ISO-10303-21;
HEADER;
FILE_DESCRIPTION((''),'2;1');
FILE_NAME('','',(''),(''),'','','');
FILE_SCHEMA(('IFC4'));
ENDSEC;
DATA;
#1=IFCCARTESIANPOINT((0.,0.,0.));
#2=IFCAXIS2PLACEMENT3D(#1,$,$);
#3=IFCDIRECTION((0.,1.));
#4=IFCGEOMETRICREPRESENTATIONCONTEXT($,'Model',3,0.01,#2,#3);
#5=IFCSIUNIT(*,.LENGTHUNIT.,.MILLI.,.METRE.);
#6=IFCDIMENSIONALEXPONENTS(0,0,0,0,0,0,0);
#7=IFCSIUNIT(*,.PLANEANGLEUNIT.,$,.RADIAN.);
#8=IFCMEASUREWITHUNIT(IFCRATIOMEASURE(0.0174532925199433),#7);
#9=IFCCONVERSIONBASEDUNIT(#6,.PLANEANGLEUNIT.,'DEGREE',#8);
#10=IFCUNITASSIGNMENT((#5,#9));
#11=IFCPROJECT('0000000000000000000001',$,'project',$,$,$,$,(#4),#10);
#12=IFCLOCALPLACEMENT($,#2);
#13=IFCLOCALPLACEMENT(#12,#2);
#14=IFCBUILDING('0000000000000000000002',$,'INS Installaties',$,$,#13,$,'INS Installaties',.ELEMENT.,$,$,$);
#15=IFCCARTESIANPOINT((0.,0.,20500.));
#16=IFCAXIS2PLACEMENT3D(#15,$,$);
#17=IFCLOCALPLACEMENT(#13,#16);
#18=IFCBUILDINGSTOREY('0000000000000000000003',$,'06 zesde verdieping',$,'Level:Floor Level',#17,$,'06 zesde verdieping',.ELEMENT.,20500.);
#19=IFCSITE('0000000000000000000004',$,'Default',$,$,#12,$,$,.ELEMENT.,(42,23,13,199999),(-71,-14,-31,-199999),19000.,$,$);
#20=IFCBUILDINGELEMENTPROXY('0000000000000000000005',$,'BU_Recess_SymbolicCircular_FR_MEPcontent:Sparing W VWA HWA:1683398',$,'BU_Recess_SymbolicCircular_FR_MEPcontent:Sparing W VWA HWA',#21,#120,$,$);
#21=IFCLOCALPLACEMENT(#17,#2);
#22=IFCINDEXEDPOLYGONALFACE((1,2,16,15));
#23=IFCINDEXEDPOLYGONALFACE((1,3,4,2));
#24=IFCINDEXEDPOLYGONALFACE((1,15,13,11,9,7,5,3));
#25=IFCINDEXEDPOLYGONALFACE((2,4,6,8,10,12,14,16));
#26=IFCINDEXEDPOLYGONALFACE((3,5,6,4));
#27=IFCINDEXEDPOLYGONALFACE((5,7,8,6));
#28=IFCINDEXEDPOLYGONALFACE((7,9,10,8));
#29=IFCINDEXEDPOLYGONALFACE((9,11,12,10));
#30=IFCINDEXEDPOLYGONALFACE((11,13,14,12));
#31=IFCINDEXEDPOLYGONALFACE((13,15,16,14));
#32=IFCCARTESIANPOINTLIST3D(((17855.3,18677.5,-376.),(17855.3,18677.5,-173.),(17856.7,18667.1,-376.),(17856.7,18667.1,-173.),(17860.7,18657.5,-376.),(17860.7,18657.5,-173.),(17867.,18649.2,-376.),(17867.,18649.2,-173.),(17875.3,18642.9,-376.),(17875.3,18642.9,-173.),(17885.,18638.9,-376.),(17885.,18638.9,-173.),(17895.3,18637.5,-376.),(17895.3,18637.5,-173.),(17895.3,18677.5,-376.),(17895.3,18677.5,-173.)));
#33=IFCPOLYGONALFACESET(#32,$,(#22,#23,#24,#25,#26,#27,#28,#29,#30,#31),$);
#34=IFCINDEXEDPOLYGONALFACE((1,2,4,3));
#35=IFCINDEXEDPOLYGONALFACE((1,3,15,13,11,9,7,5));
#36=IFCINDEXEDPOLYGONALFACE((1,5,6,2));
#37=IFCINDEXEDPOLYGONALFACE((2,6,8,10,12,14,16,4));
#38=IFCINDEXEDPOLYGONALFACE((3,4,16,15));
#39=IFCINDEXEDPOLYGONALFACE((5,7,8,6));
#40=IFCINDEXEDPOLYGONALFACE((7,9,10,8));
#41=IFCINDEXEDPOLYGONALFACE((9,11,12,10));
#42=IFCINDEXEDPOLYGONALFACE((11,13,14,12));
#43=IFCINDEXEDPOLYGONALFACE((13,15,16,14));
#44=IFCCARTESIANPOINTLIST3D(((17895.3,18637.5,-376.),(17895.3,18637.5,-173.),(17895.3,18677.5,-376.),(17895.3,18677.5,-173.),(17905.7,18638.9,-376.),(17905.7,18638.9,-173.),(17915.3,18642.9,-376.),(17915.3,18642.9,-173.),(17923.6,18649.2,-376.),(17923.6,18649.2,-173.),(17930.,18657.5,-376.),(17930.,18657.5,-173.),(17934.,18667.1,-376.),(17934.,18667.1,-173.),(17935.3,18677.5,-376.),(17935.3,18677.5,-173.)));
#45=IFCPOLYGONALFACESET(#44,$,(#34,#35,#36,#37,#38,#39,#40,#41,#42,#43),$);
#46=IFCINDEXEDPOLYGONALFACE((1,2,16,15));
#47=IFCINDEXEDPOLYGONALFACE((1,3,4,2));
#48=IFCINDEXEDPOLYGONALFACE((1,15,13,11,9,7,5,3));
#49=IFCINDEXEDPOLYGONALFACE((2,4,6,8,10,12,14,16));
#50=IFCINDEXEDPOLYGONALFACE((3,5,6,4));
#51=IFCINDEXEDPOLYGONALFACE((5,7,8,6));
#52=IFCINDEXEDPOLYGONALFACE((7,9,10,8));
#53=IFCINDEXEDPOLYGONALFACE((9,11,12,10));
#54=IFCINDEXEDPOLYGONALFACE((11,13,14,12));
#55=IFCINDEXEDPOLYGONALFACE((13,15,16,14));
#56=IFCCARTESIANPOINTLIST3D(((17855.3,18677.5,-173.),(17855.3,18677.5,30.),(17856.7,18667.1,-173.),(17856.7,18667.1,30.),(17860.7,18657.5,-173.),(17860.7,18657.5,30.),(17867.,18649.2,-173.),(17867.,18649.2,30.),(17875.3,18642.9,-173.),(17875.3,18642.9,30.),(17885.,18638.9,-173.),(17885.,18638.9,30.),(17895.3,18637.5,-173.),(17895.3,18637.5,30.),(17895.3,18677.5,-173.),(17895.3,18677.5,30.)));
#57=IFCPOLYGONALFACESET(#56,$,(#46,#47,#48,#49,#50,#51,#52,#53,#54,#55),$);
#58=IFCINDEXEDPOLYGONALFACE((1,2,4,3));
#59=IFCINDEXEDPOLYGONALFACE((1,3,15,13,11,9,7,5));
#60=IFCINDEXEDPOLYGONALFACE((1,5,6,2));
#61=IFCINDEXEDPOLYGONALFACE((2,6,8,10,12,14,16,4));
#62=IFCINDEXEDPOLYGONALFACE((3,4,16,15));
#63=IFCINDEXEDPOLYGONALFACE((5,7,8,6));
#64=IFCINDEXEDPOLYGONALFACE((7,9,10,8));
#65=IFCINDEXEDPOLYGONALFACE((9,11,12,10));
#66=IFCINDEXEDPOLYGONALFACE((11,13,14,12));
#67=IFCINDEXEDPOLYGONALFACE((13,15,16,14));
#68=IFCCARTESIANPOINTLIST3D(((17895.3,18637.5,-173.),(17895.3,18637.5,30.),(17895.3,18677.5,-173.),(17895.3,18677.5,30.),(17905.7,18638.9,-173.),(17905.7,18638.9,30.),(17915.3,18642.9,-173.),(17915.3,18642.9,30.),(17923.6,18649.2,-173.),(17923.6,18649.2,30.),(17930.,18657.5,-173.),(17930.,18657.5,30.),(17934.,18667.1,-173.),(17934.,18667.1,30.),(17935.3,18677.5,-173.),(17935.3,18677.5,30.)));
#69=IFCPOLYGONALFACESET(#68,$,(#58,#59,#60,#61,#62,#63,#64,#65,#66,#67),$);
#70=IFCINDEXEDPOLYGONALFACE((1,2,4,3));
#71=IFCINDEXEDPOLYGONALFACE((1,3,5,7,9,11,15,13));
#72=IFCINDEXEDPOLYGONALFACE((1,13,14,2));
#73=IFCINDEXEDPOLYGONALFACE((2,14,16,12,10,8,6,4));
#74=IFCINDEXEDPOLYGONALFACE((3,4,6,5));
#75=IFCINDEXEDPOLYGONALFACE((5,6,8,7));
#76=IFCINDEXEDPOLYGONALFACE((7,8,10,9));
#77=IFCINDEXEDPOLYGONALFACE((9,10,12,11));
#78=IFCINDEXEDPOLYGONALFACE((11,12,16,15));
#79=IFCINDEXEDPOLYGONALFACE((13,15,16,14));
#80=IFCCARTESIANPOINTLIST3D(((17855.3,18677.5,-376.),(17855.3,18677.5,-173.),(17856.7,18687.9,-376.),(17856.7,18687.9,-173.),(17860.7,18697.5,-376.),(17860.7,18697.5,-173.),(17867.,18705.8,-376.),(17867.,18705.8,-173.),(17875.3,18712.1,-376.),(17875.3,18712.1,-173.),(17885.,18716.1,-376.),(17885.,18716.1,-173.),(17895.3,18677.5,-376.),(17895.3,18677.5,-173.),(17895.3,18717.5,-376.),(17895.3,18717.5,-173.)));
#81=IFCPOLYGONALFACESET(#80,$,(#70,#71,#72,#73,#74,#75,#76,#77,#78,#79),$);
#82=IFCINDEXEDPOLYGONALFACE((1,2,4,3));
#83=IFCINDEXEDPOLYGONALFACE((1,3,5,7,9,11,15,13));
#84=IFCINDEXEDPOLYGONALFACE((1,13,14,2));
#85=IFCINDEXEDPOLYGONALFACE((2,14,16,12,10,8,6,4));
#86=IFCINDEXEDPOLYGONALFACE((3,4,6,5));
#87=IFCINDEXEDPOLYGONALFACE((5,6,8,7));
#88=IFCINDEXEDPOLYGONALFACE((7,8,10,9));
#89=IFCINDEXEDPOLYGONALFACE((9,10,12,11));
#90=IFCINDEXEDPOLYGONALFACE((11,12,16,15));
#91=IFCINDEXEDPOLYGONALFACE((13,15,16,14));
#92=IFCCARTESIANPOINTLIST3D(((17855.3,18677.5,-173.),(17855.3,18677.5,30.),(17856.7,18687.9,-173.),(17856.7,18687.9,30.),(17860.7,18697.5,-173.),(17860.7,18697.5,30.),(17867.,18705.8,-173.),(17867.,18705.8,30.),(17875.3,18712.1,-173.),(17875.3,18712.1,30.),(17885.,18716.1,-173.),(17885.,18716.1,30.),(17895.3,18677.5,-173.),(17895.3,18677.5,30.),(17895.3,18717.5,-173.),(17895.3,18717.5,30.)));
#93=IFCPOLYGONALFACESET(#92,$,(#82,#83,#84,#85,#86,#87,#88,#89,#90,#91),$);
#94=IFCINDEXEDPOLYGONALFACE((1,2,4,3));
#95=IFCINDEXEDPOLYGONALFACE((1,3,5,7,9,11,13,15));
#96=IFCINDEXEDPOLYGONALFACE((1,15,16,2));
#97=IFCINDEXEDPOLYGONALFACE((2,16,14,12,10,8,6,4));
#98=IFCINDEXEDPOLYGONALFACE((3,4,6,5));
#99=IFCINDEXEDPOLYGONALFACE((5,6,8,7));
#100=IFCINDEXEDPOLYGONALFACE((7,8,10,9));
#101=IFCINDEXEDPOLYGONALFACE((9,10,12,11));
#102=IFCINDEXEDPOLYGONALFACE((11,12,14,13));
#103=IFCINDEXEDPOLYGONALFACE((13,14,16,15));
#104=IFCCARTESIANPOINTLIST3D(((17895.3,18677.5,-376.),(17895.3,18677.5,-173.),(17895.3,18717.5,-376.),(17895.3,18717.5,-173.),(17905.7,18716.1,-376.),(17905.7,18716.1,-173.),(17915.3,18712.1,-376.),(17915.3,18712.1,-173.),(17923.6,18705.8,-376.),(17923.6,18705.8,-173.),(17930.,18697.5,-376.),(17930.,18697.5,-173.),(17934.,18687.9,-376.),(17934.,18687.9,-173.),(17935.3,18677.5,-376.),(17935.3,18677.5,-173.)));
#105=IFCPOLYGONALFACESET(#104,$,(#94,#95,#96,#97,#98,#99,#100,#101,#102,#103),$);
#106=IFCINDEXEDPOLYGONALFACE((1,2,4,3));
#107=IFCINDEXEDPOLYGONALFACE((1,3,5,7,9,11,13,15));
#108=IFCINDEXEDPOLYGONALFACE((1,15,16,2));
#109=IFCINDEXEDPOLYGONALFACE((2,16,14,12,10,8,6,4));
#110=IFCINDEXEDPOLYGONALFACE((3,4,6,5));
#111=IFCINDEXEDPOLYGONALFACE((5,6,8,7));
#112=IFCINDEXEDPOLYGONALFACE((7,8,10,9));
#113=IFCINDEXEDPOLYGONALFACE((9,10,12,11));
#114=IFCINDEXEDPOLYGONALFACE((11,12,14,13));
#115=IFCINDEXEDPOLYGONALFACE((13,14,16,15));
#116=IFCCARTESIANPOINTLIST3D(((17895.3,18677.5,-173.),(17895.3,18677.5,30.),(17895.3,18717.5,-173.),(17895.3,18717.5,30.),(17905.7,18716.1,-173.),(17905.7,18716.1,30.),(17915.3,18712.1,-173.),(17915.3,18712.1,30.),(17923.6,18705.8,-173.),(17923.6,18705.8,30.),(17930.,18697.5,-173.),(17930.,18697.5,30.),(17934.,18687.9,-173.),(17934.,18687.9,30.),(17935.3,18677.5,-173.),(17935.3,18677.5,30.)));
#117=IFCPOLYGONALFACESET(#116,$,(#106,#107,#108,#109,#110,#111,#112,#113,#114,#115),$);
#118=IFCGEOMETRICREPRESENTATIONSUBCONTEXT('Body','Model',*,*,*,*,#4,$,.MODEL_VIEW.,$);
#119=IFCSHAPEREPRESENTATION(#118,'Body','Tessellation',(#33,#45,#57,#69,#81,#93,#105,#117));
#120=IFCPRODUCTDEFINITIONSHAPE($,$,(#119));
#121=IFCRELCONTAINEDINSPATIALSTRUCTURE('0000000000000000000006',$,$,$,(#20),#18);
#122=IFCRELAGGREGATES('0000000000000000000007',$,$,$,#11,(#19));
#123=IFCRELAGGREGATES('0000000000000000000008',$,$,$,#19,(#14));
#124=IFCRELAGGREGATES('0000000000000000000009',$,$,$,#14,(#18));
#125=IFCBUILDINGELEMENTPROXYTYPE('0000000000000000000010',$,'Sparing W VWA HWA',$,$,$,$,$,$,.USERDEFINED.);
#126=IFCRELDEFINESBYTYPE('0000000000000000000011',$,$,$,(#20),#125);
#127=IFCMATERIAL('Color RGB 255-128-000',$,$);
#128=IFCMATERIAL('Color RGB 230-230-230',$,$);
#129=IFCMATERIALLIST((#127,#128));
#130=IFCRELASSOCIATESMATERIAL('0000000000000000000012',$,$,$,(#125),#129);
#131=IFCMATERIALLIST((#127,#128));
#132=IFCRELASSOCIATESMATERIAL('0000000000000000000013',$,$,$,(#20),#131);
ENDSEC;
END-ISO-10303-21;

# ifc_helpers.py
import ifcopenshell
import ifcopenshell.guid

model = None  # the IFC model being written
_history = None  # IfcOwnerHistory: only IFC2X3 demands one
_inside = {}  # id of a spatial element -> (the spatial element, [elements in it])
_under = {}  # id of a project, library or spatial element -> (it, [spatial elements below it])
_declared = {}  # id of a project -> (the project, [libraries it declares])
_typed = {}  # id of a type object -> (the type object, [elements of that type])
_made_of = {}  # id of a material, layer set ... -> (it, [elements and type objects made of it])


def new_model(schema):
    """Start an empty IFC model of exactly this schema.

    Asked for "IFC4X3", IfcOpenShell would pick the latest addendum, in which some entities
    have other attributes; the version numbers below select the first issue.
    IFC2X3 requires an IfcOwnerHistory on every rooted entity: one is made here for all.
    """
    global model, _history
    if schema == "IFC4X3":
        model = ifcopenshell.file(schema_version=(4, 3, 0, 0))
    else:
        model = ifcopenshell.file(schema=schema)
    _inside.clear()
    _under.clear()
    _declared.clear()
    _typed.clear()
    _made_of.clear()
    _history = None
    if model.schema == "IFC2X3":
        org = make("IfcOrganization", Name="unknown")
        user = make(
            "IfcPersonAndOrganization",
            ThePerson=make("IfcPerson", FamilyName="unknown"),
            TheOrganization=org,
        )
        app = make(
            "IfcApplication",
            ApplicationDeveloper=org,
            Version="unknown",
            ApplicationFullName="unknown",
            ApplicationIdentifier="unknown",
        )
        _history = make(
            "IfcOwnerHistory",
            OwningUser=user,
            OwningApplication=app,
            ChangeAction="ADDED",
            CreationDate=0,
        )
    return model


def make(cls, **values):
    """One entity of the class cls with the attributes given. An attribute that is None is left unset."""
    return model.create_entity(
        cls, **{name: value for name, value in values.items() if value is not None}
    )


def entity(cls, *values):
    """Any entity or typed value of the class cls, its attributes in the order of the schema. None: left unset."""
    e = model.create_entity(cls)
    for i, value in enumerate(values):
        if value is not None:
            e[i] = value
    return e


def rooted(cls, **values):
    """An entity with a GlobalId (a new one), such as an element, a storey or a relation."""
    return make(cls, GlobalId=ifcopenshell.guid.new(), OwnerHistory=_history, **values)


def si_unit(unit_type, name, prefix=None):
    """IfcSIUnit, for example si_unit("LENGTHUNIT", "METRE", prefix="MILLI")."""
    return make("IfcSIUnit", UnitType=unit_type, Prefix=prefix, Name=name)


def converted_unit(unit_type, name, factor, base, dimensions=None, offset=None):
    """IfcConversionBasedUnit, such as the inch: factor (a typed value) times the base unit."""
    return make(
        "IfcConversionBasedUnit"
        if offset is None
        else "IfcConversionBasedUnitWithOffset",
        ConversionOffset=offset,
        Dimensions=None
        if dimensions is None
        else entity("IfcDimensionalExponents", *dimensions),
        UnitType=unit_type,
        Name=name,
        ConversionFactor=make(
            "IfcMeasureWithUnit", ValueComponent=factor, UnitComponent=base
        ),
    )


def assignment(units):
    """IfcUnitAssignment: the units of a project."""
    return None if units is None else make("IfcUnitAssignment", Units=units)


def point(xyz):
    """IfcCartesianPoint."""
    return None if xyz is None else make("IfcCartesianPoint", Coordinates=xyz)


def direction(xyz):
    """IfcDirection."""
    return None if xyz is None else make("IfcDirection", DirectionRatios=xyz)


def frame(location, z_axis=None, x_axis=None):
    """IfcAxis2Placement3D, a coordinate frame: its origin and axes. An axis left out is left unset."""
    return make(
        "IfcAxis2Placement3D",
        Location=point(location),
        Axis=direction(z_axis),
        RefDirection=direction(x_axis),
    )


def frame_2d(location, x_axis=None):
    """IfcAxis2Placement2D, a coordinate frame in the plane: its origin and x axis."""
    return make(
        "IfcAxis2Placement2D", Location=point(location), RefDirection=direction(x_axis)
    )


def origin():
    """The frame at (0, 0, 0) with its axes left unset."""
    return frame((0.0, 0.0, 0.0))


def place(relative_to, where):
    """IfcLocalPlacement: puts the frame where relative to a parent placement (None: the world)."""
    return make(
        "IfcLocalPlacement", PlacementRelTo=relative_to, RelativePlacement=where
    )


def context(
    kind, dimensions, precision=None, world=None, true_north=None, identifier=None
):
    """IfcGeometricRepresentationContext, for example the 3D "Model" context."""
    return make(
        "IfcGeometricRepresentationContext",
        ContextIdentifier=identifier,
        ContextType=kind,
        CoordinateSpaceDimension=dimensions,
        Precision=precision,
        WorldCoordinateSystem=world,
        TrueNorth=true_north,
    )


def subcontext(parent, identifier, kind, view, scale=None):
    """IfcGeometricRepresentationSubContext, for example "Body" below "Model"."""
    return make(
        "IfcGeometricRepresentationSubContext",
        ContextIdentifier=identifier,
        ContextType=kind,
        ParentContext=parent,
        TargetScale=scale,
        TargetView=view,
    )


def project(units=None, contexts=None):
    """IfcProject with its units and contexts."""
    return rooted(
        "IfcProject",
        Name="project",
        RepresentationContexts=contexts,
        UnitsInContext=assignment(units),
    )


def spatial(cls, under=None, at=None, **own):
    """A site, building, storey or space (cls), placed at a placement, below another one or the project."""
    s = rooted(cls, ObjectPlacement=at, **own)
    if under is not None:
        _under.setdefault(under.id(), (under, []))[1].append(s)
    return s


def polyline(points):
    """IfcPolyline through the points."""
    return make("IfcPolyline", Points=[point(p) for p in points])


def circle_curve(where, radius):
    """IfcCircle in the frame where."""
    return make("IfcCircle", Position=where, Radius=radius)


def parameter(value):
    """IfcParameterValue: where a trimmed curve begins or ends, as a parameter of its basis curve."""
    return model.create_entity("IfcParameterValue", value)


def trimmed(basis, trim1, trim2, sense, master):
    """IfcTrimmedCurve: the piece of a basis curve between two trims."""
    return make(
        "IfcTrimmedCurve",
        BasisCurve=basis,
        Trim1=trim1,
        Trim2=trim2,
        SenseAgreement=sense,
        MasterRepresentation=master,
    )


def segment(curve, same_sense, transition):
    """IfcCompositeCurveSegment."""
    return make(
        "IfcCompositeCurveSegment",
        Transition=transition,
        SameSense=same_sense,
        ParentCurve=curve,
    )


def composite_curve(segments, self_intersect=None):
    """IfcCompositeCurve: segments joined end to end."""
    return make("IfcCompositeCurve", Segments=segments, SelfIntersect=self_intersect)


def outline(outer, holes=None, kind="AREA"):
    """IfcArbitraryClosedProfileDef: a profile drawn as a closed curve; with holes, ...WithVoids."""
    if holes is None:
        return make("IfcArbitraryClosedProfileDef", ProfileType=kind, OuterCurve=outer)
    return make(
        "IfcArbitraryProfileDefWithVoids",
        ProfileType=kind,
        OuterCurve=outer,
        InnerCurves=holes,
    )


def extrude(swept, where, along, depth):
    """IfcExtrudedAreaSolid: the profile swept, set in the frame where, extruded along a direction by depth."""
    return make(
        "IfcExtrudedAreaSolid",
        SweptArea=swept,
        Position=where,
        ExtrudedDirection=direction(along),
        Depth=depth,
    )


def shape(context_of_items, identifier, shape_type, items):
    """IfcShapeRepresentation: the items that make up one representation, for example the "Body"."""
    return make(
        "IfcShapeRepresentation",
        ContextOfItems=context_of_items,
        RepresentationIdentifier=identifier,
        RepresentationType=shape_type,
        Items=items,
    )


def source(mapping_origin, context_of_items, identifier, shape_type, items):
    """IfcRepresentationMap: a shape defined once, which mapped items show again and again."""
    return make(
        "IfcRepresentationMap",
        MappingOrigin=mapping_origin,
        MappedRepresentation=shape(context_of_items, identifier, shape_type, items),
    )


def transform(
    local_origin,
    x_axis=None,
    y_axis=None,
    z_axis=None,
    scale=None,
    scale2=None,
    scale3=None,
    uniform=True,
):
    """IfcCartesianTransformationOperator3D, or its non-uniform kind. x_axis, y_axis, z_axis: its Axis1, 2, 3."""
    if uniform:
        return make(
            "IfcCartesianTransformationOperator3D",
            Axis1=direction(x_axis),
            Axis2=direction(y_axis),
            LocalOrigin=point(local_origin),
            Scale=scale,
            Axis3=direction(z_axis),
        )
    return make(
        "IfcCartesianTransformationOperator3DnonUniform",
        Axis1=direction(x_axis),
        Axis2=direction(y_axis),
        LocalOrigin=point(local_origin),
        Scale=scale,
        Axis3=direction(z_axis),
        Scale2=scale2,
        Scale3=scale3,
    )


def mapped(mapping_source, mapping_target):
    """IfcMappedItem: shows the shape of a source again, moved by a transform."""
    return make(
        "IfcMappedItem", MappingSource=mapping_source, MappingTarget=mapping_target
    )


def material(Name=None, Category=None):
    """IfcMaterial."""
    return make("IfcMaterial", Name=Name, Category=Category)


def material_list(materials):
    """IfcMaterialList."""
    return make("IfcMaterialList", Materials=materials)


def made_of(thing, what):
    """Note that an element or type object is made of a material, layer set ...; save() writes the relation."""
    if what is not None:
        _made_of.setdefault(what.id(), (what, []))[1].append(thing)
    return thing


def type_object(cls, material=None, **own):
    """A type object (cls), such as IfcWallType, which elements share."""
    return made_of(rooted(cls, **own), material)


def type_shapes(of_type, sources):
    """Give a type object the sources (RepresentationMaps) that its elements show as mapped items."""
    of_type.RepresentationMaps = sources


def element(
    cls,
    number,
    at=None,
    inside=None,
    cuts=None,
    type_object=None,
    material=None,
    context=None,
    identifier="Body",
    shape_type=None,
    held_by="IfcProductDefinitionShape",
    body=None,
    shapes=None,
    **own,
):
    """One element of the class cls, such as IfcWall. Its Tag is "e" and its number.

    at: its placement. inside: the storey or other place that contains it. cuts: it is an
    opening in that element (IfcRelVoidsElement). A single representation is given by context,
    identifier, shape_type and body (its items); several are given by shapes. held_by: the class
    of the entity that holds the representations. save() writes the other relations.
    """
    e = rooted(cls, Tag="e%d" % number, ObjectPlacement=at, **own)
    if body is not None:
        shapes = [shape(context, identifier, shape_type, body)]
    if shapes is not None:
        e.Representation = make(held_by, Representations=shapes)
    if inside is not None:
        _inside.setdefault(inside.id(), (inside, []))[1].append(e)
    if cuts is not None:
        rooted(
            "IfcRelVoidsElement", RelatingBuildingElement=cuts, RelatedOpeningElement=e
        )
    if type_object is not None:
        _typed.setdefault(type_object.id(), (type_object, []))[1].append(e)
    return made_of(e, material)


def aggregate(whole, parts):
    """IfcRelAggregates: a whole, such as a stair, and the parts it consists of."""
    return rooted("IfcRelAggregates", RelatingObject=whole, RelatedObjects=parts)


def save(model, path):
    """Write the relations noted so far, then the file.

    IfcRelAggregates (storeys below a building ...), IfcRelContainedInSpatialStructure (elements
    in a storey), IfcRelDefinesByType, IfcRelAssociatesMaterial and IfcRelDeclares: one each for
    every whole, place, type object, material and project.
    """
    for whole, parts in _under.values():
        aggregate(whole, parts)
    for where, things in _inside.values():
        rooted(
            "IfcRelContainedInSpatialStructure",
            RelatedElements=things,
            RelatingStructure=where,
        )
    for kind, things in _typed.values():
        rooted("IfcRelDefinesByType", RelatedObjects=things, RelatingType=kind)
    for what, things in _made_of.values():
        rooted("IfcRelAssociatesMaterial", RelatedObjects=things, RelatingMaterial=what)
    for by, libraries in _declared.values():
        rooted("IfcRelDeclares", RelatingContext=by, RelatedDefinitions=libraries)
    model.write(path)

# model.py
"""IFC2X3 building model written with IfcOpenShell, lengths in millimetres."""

from ifc_helpers import new_model, entity, si_unit, converted_unit, direction, frame, frame_2d, origin, place, context, subcontext, project, spatial, polyline, circle_curve, parameter, trimmed, segment, composite_curve, outline, extrude, source, transform, mapped, material, material_list, type_object, type_shapes, element, save


model = new_model("IFC2X3")

# Units and contexts
model_context = context("Model", 3, precision=0.01, world=origin(), true_north=direction((0.0, 1.0)))
body_context = subcontext(model_context, "Body", "Model", "MODEL_VIEW")
ifc_project = project(units=[si_unit("LENGTHUNIT", "METRE", prefix="MILLI"), converted_unit("PLANEANGLEUNIT", "DEGREE", entity("IfcRatioMeasure", 0.0174532925199433), si_unit("PLANEANGLEUNIT", "RADIAN"), dimensions=[0, 0, 0, 0, 0, 0, 0])], contexts=[model_context])

# Site, building, storey
site_placement = place(None, origin())
site = spatial("IfcSite", under=ifc_project, at=site_placement, Name="Default", CompositionType="ELEMENT", RefLatitude=(42, 23, 13, 199999), RefLongitude=(-71, -14, -31, -199999), RefElevation=19000.0)
building_placement = place(site_placement, origin())
building = spatial("IfcBuilding", under=site, at=building_placement, Name="INS Installaties", LongName="INS Installaties", CompositionType="ELEMENT")
storey_placement = place(building_placement, frame((0.0, 0.0, 20500.0)))
storey = spatial("IfcBuildingStorey", under=building, at=storey_placement, Name="06 zesde verdieping", ObjectType="Level:Floor Level", LongName="06 zesde verdieping", CompositionType="ELEMENT", Elevation=20500.0)

# Building element proxy
ifc_material_1 = material(Name="Color RGB 255-128-000")
ifc_material_2 = material(Name="Color RGB 230-230-230")
ifc_material_list_1 = material_list([ifc_material_1, ifc_material_2])
building_element_proxy_type_1 = type_object("IfcBuildingElementProxyType", Name="Sparing W VWA HWA", PredefinedType="USERDEFINED", material=ifc_material_list_1)
shared_shape_1 = source(origin(), body_context, "Body", "SweptSolid", [
    extrude(outline(composite_curve([segment(trimmed(circle_curve(frame_2d((13.3, 13.3), x_axis=(1.0, 0.0)), 40.0), [parameter(180.0)], [parameter(270.0)], True, "PARAMETER"), True, "CONTINUOUS"), segment(polyline([(13.3, -26.7), (13.3, 13.3)]), True, "CONTINUOUS"), segment(polyline([(13.3, 13.3), (-26.7, 13.3)]), True, "CONTINUOUS")], self_intersect=False)), frame((13.3, 13.3, -403.0), z_axis=(0.0, 0.0, 1.0), x_axis=(-1.0, 0.0, 0.0)), (0.0, 0.0, 1.0), 203.0),
    extrude(outline(composite_curve([segment(polyline([(-26.7, -13.3), (13.3, -13.3)]), True, "CONTINUOUS"), segment(polyline([(13.3, -13.3), (13.3, 26.7)]), True, "CONTINUOUS"), segment(trimmed(circle_curve(frame_2d((13.3, -13.3), x_axis=(1.0, 0.0)), 40.0), [parameter(90.0)], [parameter(180.0)], True, "PARAMETER"), True, "CONTINUOUS")], self_intersect=False)), frame((-13.3, 13.3, -403.0)), (0.0, 0.0, 1.0), 203.0),
    extrude(outline(composite_curve([segment(trimmed(circle_curve(frame_2d((13.3, 13.3), x_axis=(1.0, 0.0)), 40.0), [parameter(180.0)], [parameter(270.0)], True, "PARAMETER"), True, "CONTINUOUS"), segment(polyline([(13.3, -26.7), (13.3, 13.3)]), True, "CONTINUOUS"), segment(polyline([(13.3, 13.3), (-26.7, 13.3)]), True, "CONTINUOUS")], self_intersect=False)), frame((13.3, 13.3, -200.0), z_axis=(0.0, 0.0, 1.0), x_axis=(-1.0, 0.0, 0.0)), (0.0, 0.0, 1.0), 203.0),
    extrude(outline(composite_curve([segment(polyline([(-26.7, -13.3), (13.3, -13.3)]), True, "CONTINUOUS"), segment(polyline([(13.3, -13.3), (13.3, 26.7)]), True, "CONTINUOUS"), segment(trimmed(circle_curve(frame_2d((13.3, -13.3), x_axis=(1.0, 0.0)), 40.0), [parameter(90.0)], [parameter(180.0)], True, "PARAMETER"), True, "CONTINUOUS")], self_intersect=False)), frame((-13.3, 13.3, -200.0)), (0.0, 0.0, 1.0), 203.0),
    extrude(outline(composite_curve([segment(polyline([(-26.7, -13.3), (13.3, -13.3)]), True, "CONTINUOUS"), segment(polyline([(13.3, -13.3), (13.3, 26.7)]), True, "CONTINUOUS"), segment(trimmed(circle_curve(frame_2d((13.3, -13.3), x_axis=(1.0, 0.0)), 40.0), [parameter(90.0)], [parameter(180.0)], True, "PARAMETER"), True, "CONTINUOUS")], self_intersect=False)), frame((13.3, -13.3, -403.0), z_axis=(0.0, 0.0, 1.0), x_axis=(-1.0, 0.0, 0.0)), (0.0, 0.0, 1.0), 203.0),
    extrude(outline(composite_curve([segment(polyline([(-26.7, -13.3), (13.3, -13.3)]), True, "CONTINUOUS"), segment(polyline([(13.3, -13.3), (13.3, 26.7)]), True, "CONTINUOUS"), segment(trimmed(circle_curve(frame_2d((13.3, -13.3), x_axis=(1.0, 0.0)), 40.0), [parameter(90.0)], [parameter(180.0)], True, "PARAMETER"), True, "CONTINUOUS")], self_intersect=False)), frame((13.3, -13.3, -200.0), z_axis=(0.0, 0.0, 1.0), x_axis=(-1.0, 0.0, 0.0)), (0.0, 0.0, 1.0), 203.0),
    extrude(outline(composite_curve([segment(trimmed(circle_curve(frame_2d((13.3, 13.3), x_axis=(1.0, 0.0)), 40.0), [parameter(180.0)], [parameter(270.0)], True, "PARAMETER"), True, "CONTINUOUS"), segment(polyline([(13.3, -26.7), (13.3, 13.3)]), True, "CONTINUOUS"), segment(polyline([(13.3, 13.3), (-26.7, 13.3)]), True, "CONTINUOUS")], self_intersect=False)), frame((-13.3, -13.3, -403.0)), (0.0, 0.0, 1.0), 203.0),
    extrude(outline(composite_curve([segment(trimmed(circle_curve(frame_2d((13.3, 13.3), x_axis=(1.0, 0.0)), 40.0), [parameter(180.0)], [parameter(270.0)], True, "PARAMETER"), True, "CONTINUOUS"), segment(polyline([(13.3, -26.7), (13.3, 13.3)]), True, "CONTINUOUS"), segment(polyline([(13.3, 13.3), (-26.7, 13.3)]), True, "CONTINUOUS")], self_intersect=False)), frame((-13.3, -13.3, -200.0)), (0.0, 0.0, 1.0), 203.0),
])
type_shapes(building_element_proxy_type_1, [shared_shape_1])
ifc_material_list_2 = material_list([ifc_material_1, ifc_material_2])
proxy_1_placement = place(storey_placement, frame((17895.3, 18677.5, 27.0), z_axis=(0.0, 0.0, 1.0), x_axis=(-1.0, 0.0, 0.0)))
element("IfcBuildingElementProxy", 1, at=proxy_1_placement, inside=storey, type_object=building_element_proxy_type_1, material=ifc_material_list_2, Name="BU_Recess_SymbolicCircular_FR_MEPcontent:Sparing W VWA HWA:1683398", ObjectType="BU_Recess_SymbolicCircular_FR_MEPcontent:Sparing W VWA HWA", context=body_context, shape_type="MappedRepresentation", body=[
    mapped(shared_shape_1, transform((0.0, 0.0, 0.0), scale=1.0)),
])

save(model, "model.ifc")
